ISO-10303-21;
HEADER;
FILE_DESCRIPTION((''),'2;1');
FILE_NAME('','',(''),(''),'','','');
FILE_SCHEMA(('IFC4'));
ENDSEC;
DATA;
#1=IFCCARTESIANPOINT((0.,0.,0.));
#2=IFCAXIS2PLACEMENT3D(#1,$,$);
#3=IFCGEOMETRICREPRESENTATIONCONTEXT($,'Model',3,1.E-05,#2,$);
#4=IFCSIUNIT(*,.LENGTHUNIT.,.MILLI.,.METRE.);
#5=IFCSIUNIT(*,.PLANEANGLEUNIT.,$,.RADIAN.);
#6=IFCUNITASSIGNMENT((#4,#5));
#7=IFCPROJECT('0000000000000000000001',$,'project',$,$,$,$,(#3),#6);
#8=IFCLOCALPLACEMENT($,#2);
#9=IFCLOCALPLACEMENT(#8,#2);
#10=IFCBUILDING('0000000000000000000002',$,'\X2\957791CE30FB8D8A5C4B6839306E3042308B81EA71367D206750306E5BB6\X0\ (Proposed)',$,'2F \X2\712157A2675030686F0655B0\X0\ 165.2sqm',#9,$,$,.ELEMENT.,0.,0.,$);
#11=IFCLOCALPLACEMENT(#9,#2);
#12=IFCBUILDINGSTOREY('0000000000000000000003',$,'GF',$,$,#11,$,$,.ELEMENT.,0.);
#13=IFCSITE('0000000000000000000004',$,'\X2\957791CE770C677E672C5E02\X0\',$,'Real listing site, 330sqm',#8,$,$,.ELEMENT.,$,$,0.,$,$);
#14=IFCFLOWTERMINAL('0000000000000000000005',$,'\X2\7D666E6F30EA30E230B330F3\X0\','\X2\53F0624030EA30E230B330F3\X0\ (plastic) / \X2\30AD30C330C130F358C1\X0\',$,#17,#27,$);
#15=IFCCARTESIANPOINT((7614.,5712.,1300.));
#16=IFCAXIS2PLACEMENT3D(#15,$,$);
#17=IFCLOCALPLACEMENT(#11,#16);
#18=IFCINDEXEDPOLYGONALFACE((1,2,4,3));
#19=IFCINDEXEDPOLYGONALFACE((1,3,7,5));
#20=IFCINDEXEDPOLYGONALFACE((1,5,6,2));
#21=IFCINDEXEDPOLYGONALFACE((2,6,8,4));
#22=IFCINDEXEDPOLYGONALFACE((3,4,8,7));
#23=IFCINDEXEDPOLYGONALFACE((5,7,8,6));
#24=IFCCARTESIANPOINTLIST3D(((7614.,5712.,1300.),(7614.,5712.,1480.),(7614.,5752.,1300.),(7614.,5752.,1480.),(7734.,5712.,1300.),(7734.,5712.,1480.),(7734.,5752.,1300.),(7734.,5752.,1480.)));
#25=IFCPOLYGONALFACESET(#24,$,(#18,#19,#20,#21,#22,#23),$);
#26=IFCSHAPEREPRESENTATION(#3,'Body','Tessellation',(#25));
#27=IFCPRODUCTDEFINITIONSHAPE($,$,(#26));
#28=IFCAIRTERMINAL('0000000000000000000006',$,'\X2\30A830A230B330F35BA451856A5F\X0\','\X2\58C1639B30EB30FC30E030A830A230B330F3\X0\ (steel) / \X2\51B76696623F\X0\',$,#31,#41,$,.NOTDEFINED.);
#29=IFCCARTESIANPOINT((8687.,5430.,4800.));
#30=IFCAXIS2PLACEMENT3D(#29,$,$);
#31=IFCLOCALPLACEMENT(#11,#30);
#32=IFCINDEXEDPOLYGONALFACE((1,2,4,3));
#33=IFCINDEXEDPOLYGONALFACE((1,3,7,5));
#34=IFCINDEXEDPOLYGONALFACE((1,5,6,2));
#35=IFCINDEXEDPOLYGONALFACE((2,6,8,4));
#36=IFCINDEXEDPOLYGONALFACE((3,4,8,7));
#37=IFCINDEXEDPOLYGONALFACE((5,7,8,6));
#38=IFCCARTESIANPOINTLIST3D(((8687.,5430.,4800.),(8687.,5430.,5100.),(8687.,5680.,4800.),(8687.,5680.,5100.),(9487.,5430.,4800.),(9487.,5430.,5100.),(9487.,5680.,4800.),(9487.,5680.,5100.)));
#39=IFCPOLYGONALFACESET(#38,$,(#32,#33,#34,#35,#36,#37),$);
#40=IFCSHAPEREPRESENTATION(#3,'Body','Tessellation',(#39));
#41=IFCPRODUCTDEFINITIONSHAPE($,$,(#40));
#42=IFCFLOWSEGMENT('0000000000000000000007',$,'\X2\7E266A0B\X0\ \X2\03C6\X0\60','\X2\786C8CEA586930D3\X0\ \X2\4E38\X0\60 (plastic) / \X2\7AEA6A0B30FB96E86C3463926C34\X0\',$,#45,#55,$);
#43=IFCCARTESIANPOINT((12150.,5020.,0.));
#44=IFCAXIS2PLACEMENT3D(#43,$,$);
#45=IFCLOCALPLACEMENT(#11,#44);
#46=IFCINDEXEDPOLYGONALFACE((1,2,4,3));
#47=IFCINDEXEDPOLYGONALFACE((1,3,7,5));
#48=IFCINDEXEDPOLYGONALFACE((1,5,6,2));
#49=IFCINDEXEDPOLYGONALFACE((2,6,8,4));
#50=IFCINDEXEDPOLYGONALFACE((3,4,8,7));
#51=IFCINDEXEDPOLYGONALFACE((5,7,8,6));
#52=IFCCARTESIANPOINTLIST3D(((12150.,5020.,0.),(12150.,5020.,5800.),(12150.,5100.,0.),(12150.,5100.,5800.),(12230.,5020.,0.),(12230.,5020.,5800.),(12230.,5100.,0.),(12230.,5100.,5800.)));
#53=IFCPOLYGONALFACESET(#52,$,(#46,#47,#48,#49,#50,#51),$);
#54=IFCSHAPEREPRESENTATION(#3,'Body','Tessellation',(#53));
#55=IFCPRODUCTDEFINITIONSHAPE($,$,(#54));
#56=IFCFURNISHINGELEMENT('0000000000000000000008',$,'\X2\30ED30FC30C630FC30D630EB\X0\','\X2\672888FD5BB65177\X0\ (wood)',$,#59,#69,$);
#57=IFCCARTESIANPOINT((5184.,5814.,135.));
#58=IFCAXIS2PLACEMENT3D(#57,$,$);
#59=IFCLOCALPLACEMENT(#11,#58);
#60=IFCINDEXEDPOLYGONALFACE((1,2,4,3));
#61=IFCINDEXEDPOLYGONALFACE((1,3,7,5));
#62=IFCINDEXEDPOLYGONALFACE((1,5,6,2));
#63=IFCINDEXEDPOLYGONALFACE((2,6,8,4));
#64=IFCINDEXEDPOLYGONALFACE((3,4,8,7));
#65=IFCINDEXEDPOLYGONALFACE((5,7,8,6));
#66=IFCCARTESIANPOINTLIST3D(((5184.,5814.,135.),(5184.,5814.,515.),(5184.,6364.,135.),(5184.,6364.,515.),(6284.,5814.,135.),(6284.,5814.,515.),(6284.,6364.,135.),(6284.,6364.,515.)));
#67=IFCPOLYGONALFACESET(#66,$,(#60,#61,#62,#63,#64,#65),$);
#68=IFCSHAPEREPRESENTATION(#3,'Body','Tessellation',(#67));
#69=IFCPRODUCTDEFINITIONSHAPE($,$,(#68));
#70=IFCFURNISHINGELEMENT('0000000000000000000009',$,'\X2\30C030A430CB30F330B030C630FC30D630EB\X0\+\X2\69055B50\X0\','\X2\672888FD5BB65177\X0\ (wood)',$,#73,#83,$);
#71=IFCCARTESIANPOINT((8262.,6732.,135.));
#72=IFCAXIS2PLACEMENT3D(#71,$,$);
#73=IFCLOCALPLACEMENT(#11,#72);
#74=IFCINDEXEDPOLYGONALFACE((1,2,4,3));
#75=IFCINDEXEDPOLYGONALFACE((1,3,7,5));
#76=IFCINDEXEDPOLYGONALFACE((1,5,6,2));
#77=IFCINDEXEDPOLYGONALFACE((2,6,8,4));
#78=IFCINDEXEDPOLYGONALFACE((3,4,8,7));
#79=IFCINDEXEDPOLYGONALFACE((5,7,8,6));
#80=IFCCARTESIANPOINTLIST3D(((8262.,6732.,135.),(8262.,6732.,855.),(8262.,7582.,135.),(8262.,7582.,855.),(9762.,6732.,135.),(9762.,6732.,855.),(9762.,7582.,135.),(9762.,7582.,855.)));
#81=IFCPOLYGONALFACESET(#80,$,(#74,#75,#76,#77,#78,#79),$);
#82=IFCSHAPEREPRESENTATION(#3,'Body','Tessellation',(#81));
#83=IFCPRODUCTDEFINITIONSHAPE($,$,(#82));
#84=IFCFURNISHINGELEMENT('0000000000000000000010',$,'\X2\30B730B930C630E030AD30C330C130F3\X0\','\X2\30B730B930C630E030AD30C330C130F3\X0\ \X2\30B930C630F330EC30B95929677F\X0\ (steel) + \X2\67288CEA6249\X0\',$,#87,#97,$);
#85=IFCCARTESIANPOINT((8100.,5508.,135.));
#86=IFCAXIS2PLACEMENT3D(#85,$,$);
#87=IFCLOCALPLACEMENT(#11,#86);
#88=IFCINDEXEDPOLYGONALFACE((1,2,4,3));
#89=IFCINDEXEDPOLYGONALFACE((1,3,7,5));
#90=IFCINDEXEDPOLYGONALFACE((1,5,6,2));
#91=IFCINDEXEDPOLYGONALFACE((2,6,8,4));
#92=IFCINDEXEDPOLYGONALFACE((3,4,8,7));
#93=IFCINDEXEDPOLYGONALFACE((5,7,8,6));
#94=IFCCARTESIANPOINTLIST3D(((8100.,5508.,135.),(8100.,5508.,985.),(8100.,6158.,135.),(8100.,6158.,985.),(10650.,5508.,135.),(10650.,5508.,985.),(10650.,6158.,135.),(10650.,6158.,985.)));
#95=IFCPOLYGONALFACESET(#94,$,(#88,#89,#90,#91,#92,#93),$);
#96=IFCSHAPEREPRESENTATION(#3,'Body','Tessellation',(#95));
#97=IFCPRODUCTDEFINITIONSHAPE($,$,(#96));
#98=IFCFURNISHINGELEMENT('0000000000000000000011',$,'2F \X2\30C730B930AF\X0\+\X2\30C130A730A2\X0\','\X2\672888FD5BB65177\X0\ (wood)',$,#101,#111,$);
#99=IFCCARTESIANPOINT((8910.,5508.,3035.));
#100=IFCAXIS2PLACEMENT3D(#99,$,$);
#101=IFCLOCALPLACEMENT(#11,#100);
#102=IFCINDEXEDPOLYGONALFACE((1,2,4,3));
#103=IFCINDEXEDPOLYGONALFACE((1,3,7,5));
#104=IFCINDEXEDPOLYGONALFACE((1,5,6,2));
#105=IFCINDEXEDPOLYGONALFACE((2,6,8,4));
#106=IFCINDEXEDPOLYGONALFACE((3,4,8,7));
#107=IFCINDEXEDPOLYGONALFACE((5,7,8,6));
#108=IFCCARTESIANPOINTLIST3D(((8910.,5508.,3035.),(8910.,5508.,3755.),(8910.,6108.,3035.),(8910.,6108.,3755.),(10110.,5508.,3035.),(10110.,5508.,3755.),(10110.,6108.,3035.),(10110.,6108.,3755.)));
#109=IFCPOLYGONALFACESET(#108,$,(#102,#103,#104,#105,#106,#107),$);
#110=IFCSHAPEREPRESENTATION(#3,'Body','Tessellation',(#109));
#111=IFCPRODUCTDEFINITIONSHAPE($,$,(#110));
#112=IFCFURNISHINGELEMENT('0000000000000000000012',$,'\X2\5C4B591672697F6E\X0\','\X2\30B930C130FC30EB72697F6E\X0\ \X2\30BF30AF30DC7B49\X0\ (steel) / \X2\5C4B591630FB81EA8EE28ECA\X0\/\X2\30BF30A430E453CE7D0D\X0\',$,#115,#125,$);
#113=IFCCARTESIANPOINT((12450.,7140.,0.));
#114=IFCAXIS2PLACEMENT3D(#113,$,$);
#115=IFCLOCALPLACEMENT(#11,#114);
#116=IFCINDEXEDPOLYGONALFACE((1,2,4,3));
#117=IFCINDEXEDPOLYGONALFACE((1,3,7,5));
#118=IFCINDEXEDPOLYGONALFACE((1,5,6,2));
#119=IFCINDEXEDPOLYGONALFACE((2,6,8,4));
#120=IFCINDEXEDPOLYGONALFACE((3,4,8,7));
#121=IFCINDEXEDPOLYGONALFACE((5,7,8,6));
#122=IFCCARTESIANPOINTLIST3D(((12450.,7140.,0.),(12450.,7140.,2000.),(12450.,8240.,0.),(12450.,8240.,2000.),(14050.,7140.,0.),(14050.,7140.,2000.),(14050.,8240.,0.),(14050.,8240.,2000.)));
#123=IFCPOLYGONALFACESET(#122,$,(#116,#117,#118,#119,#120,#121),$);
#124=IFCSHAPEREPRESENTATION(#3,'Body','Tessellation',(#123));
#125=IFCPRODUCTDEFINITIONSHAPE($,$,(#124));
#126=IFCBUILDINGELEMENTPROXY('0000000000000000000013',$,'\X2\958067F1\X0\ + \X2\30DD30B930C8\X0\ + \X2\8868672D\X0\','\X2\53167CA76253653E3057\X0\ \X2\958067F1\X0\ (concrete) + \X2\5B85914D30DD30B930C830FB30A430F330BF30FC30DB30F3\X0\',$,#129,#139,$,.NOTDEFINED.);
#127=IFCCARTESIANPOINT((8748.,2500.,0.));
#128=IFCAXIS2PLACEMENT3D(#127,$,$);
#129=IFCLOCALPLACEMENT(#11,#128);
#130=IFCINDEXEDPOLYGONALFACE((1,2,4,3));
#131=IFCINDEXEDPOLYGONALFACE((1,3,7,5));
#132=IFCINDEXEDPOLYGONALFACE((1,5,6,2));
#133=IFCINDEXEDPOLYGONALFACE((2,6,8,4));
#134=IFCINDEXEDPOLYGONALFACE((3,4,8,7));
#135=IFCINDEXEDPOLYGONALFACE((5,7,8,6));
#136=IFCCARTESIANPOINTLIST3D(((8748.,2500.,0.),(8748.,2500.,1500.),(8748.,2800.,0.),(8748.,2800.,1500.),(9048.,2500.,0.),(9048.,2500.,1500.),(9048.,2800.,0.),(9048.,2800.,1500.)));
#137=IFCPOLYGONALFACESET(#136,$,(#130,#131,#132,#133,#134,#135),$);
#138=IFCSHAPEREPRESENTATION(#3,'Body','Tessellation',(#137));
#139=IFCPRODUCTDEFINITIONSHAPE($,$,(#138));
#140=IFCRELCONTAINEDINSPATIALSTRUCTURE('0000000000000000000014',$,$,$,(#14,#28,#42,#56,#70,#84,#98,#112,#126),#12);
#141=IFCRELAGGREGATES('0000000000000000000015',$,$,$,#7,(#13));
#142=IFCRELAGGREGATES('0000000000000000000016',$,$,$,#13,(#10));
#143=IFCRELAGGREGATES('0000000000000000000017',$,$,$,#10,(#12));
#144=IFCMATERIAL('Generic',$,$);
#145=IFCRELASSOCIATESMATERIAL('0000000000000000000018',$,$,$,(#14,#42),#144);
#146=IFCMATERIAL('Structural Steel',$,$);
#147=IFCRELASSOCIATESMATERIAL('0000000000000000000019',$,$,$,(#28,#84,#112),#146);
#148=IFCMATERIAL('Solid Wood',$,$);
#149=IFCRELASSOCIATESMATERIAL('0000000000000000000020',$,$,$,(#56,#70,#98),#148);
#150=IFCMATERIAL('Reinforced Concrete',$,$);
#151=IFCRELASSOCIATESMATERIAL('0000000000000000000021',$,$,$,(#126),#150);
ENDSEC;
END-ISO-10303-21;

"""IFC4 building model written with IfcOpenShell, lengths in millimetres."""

from ifc_helpers import new_model, si_unit, frame, frame_2d, origin, place, context, project, spatial, rectangle, extrude, material, element, save


model = new_model("IFC4")

# Units and contexts
model_context = context("Model", 3, precision=1e-05, world=origin())
ifc_project = project(units=[si_unit("LENGTHUNIT", "METRE", prefix="MILLI"), si_unit("PLANEANGLEUNIT", "RADIAN")], contexts=[model_context])

# Site, building, storey
site_placement = place(None, origin())
site = spatial("IfcSite", under=ifc_project, at=site_placement, Name="長野県松本市", ObjectType="Real listing site, 330sqm", CompositionType="ELEMENT", RefElevation=0.0)
building_placement = place(site_placement, origin())
building = spatial("IfcBuilding", under=site, at=building_placement, Name="長野・越屋根のある自然素材の家 (Proposed)", ObjectType="2F 無垢材と漆喰 165.2sqm", CompositionType="ELEMENT", ElevationOfRefHeight=0.0, ElevationOfTerrain=0.0)
storey_placement = place(building_placement, origin())
storey = spatial("IfcBuildingStorey", under=building, at=storey_placement, Name="GF", CompositionType="ELEMENT", Elevation=0.0)

# Shared definitions
ifc_material_1 = material(Name="Solid Wood")

# Shared definitions
ifc_material_2 = material(Name="Reinforced Concrete")

# Shared definitions
ifc_material_3 = material(Name="Structural Steel")

# Flow terminal
ifc_material_4 = material(Name="Generic")
flow_terminal_1_placement = place(storey_placement, frame((7614.0, 5712.0, 1300.0)))
element("IfcFlowTerminal", 1, at=flow_terminal_1_placement, inside=storey, material=ifc_material_4, Name="給湯リモコン", Description="台所リモコン (plastic) / キッチン壁", context=model_context, shape_type="SweptSolid", body=[
    extrude(rectangle(XDim=120.0, YDim=40.0, at=frame_2d((60.0, 20.0))), frame((7614.0, 5712.0, 1300.0)), (0.0, 0.0, 1.0), 180.0),
])

# Air terminal
air_terminal_placement = place(storey_placement, frame((8687.0, 5430.0, 4800.0)))
element("IfcAirTerminal", 2, at=air_terminal_placement, inside=storey, material=ifc_material_3, Name="エアコン室内機", Description="壁掛ルームエアコン (steel) / 冷暖房", PredefinedType="NOTDEFINED", context=model_context, shape_type="SweptSolid", body=[
    extrude(rectangle(XDim=800.0, YDim=250.0, at=frame_2d((400.0, 125.0))), frame((8687.0, 5430.0, 4800.0)), (0.0, 0.0, 1.0), 300.0),
])

# Flow segment
flow_segment_placement = place(storey_placement, frame((12150.0, 5020.0, 0.0)))
element("IfcFlowSegment", 3, at=flow_segment_placement, inside=storey, material=ifc_material_4, Name="縦樋 φ60", Description="硬質塩ビ 丸60 (plastic) / 竪樋・雨水排水", context=model_context, shape_type="SweptSolid", body=[
    extrude(rectangle(XDim=80.0, YDim=80.0, at=frame_2d((40.0, 40.0))), frame((12150.0, 5020.0, 0.0)), (0.0, 0.0, 1.0), 5800.0),
])

# Furnishing elements
furnishing_1_placement = place(storey_placement, frame((5184.0, 5814.0, 135.0)))
element("IfcFurnishingElement", 4, at=furnishing_1_placement, inside=storey, material=ifc_material_1, Name="ローテーブル", Description="木製家具 (wood)", context=model_context, shape_type="SweptSolid", body=[
    extrude(rectangle(XDim=1100.0, YDim=550.0, at=frame_2d((550.0, 275.0))), frame((5184.0, 5814.0, 135.0)), (0.0, 0.0, 1.0), 380.0),
])
furnishing_2_placement = place(storey_placement, frame((8262.0, 6732.0, 135.0)))
element("IfcFurnishingElement", 5, at=furnishing_2_placement, inside=storey, material=ifc_material_1, Name="ダイニングテーブル+椅子", Description="木製家具 (wood)", context=model_context, shape_type="SweptSolid", body=[
    extrude(rectangle(XDim=1500.0, YDim=850.0, at=frame_2d((750.0, 425.0))), frame((8262.0, 6732.0, 135.0)), (0.0, 0.0, 1.0), 720.0),
])
furnishing_3_placement = place(storey_placement, frame((8100.0, 5508.0, 135.0)))
element("IfcFurnishingElement", 6, at=furnishing_3_placement, inside=storey, material=ifc_material_3, Name="システムキッチン", Description="システムキッチン ステンレス天板 (steel) + 木質扉", context=model_context, shape_type="SweptSolid", body=[
    extrude(rectangle(XDim=2550.0, YDim=650.0, at=frame_2d((1275.0, 325.0))), frame((8100.0, 5508.0, 135.0)), (0.0, 0.0, 1.0), 850.0),
])
furnishing_4_placement = place(storey_placement, frame((8910.0, 5508.0, 3035.0)))
element("IfcFurnishingElement", 7, at=furnishing_4_placement, inside=storey, material=ifc_material_1, Name="2F デスク+チェア", Description="木製家具 (wood)", context=model_context, shape_type="SweptSolid", body=[
    extrude(rectangle(XDim=1200.0, YDim=600.0, at=frame_2d((600.0, 300.0))), frame((8910.0, 5508.0, 3035.0)), (0.0, 0.0, 1.0), 720.0),
])
furnishing_5_placement = place(storey_placement, frame((12450.0, 7140.0, 0.0)))
element("IfcFurnishingElement", 8, at=furnishing_5_placement, inside=storey, material=ifc_material_3, Name="屋外物置", Description="スチール物置 タクボ等 (steel) / 屋外・自転車/タイヤ収納", context=model_context, shape_type="SweptSolid", body=[
    extrude(rectangle(XDim=1600.0, YDim=1100.0, at=frame_2d((800.0, 550.0))), frame((12450.0, 7140.0, 0.0)), (0.0, 0.0, 1.0), 2000.0),
])

# Building element proxy
proxy_placement = place(storey_placement, frame((8748.0, 2500.0, 0.0)))
element("IfcBuildingElementProxy", 9, at=proxy_placement, inside=storey, material=ifc_material_2, Name="門柱 + ポスト + 表札", Description="化粧打放し 門柱 (concrete) + 宅配ポスト・インターホン", PredefinedType="NOTDEFINED", context=model_context, shape_type="SweptSolid", body=[
    extrude(rectangle(XDim=300.0, YDim=300.0, at=frame_2d((150.0, 150.0))), frame((8748.0, 2500.0, 0.0)), (0.0, 0.0, 1.0), 1500.0),
])

save(model, "model.ifc")
